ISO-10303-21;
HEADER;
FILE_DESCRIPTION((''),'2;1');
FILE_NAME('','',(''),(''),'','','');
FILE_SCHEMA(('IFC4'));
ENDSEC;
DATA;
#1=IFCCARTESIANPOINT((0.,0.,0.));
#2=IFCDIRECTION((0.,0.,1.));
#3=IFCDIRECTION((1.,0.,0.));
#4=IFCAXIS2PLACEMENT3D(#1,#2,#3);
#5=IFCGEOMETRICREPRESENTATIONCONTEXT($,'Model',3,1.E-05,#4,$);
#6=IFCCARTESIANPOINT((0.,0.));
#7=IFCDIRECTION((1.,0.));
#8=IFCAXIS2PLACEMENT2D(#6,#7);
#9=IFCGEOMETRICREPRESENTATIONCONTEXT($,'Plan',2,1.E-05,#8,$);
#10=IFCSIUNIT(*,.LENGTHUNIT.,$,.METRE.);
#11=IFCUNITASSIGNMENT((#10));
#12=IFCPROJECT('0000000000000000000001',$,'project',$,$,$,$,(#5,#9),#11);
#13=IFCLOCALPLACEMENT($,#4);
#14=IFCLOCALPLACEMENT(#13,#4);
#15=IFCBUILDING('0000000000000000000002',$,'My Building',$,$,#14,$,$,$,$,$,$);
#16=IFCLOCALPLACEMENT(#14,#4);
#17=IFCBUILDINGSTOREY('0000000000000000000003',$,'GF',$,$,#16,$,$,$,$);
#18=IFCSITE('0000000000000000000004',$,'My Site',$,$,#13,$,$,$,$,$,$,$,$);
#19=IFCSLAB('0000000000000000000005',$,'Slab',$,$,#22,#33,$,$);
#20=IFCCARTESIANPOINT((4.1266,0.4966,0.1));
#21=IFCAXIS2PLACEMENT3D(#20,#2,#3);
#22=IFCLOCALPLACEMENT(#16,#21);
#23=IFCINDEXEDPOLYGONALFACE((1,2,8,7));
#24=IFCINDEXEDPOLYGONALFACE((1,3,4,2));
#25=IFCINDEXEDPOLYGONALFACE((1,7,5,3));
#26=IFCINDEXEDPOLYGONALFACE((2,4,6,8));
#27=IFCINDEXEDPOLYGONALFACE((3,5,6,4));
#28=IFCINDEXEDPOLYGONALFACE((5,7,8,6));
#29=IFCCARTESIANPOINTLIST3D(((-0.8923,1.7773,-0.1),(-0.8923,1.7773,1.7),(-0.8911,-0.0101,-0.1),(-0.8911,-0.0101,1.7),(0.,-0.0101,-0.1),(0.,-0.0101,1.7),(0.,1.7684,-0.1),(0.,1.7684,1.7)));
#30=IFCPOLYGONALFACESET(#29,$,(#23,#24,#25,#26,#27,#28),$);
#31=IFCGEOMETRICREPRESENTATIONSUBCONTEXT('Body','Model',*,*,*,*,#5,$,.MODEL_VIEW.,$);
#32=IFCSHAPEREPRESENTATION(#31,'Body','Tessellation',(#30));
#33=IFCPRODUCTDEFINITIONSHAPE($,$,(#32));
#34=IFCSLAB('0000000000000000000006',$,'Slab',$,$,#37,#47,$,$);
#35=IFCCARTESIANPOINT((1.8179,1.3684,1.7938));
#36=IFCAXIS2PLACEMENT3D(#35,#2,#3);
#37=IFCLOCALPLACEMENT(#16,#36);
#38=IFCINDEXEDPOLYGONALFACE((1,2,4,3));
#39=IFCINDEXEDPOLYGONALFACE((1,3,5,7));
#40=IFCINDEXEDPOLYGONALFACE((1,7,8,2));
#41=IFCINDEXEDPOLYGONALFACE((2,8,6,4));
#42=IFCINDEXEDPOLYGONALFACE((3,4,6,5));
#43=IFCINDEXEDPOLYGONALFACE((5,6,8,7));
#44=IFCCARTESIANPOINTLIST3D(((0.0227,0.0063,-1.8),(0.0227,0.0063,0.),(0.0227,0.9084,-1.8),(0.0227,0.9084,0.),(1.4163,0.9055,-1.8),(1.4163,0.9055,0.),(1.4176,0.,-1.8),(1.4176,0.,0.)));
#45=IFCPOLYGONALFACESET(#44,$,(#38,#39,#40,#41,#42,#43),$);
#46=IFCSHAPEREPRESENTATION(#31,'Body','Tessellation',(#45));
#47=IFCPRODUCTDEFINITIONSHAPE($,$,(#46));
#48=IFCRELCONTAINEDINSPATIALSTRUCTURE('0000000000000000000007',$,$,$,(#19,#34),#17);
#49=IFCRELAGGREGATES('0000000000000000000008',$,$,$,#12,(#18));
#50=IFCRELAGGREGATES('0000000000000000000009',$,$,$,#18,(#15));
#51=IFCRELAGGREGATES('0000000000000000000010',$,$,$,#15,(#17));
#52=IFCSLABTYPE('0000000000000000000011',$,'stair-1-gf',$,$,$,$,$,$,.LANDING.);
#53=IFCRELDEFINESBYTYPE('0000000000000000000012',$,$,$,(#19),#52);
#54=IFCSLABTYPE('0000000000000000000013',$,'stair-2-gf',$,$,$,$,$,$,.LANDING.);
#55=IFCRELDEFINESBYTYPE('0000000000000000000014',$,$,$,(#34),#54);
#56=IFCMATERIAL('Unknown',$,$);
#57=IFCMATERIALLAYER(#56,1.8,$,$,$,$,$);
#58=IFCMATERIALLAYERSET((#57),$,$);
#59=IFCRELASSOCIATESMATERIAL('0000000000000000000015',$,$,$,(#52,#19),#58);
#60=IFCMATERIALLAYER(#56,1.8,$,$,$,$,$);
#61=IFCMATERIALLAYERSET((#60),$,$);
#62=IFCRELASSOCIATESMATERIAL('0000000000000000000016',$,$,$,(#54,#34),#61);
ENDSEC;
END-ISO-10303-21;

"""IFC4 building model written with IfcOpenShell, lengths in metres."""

from ifc_helpers import new_model, si_unit, frame, origin_with_axes, origin_2d_with_axis, place, context, subcontext, project, spatial, indexed_curve, outline, extrude, material, layer, layer_set, layer_usage, type_object, element, save


model = new_model("IFC4")

# Units and contexts
model_context = context("Model", 3, precision=1e-05, world=origin_with_axes())
plan_context = context("Plan", 2, precision=1e-05, world=origin_2d_with_axis())
body_context_1 = subcontext(model_context, "Body", "Model", "MODEL_VIEW")
ifc_project = project(units=[si_unit("LENGTHUNIT", "METRE")], contexts=[model_context, plan_context])

# Site, building, storey
site_placement = place(None, origin_with_axes())
site = spatial("IfcSite", under=ifc_project, at=site_placement, Name="My Site")
building_placement = place(site_placement, origin_with_axes())
building = spatial("IfcBuilding", under=site, at=building_placement, Name="My Building")
storey_placement = place(building_placement, origin_with_axes())
storey = spatial("IfcBuildingStorey", under=building, at=storey_placement, Name="GF")

# Slabs
ifc_material_1 = material(Name="Unknown")
ifc_layer_1 = layer(ifc_material_1, 1.8)
ifc_layer_set_1 = layer_set([ifc_layer_1])
slab_type_1 = type_object("IfcSlabType", Name="stair-1-gf", PredefinedType="LANDING", material=ifc_layer_set_1)
ifc_layer_usage_1 = layer_usage(ifc_layer_set_1, "AXIS3", "POSITIVE", -0.1)
slab_1_placement = place(storey_placement, frame((4.1266, 0.4966, 0.1), z_axis=(0.0, 0.0, 1.0), x_axis=(1.0, 0.0, 0.0)))
element("IfcSlab", 1, at=slab_1_placement, inside=storey, type_object=slab_type_1, material=ifc_layer_usage_1, Name="Slab", context=body_context_1, shape_type="SweptSolid", body=[
    extrude(outline(indexed_curve([(0.0, -0.0101), (0.0, 1.7684), (-0.8923, 1.7773), (-0.8911, -0.0101), (0.0, -0.0101)])), frame((0.0, 0.0, -0.1), z_axis=(0.0, 0.0, 1.0), x_axis=(1.0, 0.0, 0.0)), (0.0, 0.0, 1.0), 1.8),
])
ifc_layer_2 = layer(ifc_material_1, 1.8)
ifc_layer_set_2 = layer_set([ifc_layer_2])
ifc_layer_usage_2 = layer_usage(ifc_layer_set_2, "AXIS3", "POSITIVE", -1.8)
slab_type_2 = type_object("IfcSlabType", Name="stair-2-gf", PredefinedType="LANDING", material=ifc_layer_set_2)
slab_2_placement = place(storey_placement, frame((1.8179, 1.3684, 1.7938), z_axis=(0.0, 0.0, 1.0), x_axis=(1.0, 0.0, 0.0)))
element("IfcSlab", 2, at=slab_2_placement, inside=storey, type_object=slab_type_2, material=ifc_layer_usage_2, Name="Slab", context=body_context_1, shape_type="SweptSolid", body=[
    extrude(outline(indexed_curve([(0.0227, 0.0063), (1.4176, 0.0), (1.4163, 0.9055), (0.0227, 0.9084), (0.0227, 0.0063)])), frame((0.0, 0.0, -1.8), z_axis=(0.0, 0.0, 1.0), x_axis=(1.0, 0.0, 0.0)), (0.0, 0.0, 1.0), 1.8),
])

save(model, "model.ifc")
